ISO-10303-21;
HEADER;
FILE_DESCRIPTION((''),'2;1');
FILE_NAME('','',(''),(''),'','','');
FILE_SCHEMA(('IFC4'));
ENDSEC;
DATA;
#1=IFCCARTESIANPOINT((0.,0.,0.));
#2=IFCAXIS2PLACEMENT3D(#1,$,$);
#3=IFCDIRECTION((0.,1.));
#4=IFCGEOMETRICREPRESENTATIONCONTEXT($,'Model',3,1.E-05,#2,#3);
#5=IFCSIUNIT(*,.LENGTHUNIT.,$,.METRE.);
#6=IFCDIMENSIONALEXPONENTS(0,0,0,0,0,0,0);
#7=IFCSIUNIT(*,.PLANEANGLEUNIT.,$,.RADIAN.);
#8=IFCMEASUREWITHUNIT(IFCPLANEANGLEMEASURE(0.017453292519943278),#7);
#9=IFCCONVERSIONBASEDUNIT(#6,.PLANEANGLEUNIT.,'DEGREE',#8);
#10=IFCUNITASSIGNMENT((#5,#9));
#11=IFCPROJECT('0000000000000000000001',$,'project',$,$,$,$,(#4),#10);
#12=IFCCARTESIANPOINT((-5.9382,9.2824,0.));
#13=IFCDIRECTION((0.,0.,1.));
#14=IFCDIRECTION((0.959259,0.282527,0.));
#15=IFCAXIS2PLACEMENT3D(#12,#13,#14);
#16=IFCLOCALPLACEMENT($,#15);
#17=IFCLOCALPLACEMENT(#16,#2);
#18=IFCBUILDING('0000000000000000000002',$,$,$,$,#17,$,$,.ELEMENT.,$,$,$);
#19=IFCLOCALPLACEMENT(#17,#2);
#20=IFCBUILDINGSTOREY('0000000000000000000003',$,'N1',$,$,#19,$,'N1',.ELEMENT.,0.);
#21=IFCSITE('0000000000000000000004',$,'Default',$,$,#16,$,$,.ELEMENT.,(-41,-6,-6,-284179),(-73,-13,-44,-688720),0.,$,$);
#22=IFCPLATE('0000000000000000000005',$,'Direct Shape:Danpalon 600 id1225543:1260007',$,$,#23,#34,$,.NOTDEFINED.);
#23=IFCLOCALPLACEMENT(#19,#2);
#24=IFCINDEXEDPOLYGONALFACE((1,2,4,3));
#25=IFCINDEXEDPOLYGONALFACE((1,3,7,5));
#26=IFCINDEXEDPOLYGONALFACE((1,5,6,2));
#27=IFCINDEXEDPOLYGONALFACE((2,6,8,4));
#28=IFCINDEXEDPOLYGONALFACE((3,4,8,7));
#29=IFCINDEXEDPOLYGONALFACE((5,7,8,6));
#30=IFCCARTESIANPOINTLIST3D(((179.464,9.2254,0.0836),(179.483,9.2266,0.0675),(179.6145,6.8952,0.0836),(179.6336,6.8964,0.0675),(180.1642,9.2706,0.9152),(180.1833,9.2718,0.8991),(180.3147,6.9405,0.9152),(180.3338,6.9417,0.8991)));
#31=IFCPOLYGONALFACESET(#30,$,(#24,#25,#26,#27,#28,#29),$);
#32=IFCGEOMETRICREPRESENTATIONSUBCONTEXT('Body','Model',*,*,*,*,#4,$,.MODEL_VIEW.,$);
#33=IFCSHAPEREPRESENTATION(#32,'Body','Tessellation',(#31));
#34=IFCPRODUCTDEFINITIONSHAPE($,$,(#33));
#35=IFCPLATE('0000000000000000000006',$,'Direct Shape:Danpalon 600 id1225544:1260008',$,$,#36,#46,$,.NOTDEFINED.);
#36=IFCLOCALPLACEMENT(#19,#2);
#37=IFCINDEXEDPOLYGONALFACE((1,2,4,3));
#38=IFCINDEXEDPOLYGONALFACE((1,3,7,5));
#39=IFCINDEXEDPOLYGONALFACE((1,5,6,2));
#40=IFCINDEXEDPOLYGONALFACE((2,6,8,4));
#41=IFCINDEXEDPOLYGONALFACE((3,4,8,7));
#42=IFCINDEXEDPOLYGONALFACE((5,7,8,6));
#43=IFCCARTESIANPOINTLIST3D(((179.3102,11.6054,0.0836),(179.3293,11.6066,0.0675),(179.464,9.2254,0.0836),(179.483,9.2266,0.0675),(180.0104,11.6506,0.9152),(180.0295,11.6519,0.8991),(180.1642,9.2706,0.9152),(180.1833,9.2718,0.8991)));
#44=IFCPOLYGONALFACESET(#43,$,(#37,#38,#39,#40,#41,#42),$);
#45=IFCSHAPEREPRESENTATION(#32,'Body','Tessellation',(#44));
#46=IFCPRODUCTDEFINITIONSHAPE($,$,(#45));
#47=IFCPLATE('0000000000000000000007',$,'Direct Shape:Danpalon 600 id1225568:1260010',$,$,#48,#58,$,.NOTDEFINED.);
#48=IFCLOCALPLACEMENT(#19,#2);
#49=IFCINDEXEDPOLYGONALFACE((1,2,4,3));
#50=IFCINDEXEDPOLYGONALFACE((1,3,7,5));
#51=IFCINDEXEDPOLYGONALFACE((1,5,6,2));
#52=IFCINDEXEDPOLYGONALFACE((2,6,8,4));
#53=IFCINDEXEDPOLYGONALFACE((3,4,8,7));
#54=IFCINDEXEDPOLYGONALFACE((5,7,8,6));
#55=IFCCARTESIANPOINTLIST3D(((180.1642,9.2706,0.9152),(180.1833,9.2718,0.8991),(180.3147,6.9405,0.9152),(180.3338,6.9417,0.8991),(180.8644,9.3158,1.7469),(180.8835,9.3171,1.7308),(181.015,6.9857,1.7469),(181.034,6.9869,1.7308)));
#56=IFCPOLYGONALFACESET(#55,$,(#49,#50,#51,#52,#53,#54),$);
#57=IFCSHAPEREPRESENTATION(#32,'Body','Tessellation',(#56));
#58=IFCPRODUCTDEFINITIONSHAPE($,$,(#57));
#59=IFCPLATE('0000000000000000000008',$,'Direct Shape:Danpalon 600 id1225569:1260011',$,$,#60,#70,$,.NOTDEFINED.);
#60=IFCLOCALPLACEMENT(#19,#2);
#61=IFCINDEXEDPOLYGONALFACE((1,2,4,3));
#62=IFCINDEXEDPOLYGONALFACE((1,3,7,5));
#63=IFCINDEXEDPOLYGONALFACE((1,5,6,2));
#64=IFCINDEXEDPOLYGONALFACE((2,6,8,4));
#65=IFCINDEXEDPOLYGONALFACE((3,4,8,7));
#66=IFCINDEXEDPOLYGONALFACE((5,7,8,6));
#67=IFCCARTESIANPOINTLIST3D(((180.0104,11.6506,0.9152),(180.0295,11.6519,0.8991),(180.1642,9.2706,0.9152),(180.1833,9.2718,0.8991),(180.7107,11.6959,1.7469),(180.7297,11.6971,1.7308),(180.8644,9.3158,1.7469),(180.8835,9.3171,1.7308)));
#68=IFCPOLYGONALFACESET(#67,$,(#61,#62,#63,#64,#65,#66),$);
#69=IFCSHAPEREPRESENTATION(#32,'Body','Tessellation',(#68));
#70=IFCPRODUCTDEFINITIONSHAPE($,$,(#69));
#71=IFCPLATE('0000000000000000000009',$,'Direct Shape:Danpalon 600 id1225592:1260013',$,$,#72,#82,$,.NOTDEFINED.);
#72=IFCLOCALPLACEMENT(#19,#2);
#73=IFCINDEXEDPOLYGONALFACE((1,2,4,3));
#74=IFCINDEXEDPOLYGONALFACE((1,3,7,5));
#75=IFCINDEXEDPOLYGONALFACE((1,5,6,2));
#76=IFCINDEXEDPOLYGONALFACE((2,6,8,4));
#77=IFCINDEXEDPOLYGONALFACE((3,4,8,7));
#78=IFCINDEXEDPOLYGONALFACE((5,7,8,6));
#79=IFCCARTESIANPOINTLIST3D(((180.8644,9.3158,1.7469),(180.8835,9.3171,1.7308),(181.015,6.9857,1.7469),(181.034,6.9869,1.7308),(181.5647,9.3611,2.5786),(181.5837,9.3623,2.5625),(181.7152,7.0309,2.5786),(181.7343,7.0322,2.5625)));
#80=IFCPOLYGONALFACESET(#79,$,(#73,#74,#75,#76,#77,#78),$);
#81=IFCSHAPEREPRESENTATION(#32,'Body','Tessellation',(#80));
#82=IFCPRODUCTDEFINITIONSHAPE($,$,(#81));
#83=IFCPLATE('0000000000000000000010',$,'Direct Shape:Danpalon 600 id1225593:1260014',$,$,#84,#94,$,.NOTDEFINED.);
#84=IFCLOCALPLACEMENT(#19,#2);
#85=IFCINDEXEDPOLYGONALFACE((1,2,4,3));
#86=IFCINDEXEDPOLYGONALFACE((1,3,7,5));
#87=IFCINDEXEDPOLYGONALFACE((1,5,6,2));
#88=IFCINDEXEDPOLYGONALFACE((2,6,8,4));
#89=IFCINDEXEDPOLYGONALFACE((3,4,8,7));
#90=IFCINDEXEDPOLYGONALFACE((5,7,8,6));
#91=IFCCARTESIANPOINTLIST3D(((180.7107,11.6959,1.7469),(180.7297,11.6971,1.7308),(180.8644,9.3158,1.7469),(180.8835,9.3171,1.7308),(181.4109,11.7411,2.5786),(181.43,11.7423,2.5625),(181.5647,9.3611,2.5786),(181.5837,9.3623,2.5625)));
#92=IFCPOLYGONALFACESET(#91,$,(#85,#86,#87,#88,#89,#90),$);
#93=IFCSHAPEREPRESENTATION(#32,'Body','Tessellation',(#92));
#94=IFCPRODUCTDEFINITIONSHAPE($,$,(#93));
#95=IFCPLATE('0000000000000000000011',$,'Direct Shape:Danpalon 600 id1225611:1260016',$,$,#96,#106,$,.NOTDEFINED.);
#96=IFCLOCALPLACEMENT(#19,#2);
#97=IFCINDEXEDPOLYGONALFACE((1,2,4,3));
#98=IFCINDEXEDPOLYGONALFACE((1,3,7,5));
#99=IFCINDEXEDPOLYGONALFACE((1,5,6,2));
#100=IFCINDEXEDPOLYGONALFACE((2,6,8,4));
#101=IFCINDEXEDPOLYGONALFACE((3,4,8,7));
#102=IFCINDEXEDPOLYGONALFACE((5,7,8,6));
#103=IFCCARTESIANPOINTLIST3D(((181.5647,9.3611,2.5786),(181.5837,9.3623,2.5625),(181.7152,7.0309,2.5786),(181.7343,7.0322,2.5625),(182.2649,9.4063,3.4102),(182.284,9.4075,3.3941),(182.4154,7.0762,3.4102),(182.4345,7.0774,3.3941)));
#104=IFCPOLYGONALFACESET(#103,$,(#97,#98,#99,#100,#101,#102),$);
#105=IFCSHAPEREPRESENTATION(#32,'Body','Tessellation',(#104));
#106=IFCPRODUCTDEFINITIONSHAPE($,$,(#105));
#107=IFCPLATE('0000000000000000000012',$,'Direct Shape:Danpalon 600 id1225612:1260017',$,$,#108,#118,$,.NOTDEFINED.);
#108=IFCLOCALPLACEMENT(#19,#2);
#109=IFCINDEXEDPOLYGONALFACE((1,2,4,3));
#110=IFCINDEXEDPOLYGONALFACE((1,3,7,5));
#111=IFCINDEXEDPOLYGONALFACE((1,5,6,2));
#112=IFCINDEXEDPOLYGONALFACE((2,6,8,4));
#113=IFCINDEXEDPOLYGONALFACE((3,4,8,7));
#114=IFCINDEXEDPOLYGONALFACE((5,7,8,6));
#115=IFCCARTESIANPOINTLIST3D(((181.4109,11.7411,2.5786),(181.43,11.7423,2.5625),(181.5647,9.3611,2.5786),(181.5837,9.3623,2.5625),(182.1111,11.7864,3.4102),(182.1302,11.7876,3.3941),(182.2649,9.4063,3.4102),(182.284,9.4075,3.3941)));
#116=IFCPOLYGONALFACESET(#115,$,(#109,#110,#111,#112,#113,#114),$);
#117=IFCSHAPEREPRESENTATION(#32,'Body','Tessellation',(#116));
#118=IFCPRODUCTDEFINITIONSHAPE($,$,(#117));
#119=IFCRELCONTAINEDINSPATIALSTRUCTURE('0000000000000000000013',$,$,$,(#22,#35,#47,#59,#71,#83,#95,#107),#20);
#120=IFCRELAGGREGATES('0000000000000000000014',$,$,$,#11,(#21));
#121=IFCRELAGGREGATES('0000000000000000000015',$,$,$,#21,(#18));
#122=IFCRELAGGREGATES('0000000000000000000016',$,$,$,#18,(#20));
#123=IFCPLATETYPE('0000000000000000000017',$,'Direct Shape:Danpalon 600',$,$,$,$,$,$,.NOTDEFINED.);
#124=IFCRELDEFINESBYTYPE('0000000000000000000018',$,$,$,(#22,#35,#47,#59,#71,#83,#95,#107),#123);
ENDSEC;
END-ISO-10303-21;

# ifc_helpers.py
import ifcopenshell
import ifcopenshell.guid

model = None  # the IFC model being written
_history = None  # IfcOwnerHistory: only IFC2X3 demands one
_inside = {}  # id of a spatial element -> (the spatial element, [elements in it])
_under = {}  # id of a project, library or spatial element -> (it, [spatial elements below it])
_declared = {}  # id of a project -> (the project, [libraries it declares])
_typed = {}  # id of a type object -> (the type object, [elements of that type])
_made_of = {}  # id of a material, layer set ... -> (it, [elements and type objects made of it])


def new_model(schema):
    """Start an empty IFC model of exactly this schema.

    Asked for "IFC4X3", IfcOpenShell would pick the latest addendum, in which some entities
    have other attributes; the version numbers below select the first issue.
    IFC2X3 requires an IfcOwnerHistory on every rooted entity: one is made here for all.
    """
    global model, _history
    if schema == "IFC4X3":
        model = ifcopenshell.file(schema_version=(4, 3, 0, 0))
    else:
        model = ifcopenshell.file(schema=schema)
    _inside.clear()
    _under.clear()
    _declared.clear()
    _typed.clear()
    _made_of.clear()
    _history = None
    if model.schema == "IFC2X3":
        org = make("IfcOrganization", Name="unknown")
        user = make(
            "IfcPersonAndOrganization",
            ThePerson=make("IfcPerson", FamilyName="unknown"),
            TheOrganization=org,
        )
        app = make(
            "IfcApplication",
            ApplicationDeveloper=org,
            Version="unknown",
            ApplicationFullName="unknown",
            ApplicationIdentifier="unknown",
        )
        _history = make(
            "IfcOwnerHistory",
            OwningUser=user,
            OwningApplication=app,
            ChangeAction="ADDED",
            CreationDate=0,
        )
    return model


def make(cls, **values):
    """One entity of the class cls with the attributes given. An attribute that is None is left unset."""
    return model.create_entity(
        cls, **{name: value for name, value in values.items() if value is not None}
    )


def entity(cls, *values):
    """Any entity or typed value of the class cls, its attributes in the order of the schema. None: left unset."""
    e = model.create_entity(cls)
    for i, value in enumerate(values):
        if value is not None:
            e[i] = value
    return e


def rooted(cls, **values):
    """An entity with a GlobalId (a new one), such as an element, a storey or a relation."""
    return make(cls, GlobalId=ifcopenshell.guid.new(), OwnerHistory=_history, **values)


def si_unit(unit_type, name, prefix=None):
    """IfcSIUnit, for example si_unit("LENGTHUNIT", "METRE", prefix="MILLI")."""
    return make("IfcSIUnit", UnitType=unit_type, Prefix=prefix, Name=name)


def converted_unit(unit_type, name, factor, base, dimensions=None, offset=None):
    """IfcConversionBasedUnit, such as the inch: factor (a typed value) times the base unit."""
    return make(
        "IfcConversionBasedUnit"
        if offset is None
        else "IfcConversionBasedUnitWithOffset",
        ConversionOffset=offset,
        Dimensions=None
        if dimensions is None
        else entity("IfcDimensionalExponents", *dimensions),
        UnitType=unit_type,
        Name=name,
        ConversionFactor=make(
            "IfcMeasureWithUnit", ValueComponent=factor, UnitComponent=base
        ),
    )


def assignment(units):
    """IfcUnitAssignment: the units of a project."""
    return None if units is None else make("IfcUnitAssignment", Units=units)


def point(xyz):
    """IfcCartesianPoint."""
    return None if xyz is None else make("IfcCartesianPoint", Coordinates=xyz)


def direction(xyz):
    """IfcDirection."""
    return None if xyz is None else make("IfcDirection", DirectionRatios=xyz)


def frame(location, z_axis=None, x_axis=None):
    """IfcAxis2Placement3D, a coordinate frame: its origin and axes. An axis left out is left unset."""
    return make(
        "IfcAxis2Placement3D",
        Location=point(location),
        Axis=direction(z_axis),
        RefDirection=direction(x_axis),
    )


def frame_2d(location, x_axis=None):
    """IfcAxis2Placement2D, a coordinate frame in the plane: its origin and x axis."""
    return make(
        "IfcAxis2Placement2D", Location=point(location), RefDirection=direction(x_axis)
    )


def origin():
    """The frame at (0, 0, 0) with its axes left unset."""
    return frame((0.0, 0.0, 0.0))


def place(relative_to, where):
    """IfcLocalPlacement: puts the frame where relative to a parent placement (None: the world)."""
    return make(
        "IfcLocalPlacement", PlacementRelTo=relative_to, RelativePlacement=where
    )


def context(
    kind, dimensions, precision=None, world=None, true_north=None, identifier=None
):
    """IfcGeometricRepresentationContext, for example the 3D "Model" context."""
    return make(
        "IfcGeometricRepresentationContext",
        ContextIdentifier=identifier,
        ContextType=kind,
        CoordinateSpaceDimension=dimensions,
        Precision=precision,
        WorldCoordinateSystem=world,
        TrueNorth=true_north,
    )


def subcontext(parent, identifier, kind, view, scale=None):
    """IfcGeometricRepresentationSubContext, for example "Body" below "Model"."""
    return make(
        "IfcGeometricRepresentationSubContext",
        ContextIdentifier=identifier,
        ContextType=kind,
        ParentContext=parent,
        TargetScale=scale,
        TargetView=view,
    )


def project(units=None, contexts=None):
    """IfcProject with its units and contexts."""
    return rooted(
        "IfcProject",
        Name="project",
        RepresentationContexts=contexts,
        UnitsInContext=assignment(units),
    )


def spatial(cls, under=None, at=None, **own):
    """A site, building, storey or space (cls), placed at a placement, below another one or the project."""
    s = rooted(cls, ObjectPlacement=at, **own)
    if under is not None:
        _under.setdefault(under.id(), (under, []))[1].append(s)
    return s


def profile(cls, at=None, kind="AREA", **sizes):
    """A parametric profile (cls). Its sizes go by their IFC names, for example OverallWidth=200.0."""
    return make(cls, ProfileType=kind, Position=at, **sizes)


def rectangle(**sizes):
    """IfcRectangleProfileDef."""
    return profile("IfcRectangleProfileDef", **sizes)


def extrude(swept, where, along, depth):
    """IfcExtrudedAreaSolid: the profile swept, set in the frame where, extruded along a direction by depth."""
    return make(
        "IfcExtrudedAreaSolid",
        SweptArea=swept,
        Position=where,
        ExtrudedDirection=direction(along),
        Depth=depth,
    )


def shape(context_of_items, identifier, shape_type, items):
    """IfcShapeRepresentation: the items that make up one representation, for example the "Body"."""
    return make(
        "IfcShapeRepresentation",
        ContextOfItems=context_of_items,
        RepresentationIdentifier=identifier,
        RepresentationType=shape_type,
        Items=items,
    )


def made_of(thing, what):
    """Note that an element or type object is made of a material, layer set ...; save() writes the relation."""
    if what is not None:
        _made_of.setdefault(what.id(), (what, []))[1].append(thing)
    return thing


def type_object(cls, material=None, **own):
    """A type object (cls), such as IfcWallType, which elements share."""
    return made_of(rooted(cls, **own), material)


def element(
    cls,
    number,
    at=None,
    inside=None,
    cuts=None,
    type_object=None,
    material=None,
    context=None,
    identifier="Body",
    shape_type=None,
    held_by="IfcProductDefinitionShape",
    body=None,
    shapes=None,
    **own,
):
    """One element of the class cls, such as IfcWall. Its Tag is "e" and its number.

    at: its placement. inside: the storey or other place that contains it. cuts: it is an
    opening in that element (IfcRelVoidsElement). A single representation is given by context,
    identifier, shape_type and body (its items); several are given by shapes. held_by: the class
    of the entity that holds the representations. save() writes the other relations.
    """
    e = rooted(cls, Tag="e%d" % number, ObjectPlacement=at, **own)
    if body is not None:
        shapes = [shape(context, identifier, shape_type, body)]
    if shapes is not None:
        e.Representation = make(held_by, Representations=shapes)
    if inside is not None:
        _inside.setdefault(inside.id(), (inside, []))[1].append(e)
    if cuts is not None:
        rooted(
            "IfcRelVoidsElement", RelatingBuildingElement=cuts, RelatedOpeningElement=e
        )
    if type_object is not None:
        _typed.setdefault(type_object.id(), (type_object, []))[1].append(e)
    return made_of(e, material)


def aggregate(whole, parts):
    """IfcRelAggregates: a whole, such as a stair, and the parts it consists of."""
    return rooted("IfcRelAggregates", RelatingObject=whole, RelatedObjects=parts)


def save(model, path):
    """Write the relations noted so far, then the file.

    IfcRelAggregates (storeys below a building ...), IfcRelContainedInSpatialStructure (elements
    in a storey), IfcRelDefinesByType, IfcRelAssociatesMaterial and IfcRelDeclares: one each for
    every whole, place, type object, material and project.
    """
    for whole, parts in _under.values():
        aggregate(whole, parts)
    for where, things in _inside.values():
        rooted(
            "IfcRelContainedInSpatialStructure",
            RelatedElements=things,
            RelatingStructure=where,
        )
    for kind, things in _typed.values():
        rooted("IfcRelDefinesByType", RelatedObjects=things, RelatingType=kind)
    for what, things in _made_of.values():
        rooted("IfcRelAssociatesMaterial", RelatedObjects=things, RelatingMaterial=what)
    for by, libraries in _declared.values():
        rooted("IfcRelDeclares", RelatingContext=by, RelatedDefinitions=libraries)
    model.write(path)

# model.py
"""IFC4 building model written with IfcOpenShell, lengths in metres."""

from ifc_helpers import new_model, entity, si_unit, converted_unit, direction, frame, frame_2d, origin, place, context, subcontext, project, spatial, rectangle, extrude, type_object, element, save


model = new_model("IFC4")

# Units and contexts
model_context = context("Model", 3, precision=1e-05, world=origin(), true_north=direction((0.0, 1.0)))
body_context = subcontext(model_context, "Body", "Model", "MODEL_VIEW")
ifc_project = project(units=[si_unit("LENGTHUNIT", "METRE"), converted_unit("PLANEANGLEUNIT", "DEGREE", entity("IfcPlaneAngleMeasure", 0.017453292519943278), si_unit("PLANEANGLEUNIT", "RADIAN"), dimensions=[0, 0, 0, 0, 0, 0, 0])], contexts=[model_context])

# Site, building, storey
site_placement = place(None, frame((-5.9382, 9.2824, 0.0), z_axis=(0.0, 0.0, 1.0), x_axis=(0.959259, 0.282527, 0.0)))
site = spatial("IfcSite", under=ifc_project, at=site_placement, Name="Default", CompositionType="ELEMENT", RefLatitude=(-41, -6, -6, -284179), RefLongitude=(-73, -13, -44, -688720), RefElevation=0.0)
building_placement = place(site_placement, origin())
building = spatial("IfcBuilding", under=site, at=building_placement, CompositionType="ELEMENT")
storey_placement = place(building_placement, origin())
storey = spatial("IfcBuildingStorey", under=building, at=storey_placement, Name="N1", LongName="N1", CompositionType="ELEMENT", Elevation=0.0)

# Plates
plate_type = type_object("IfcPlateType", Name="Direct Shape:Danpalon 600", PredefinedType="NOTDEFINED")
plate_1_placement = place(storey_placement, origin())
element("IfcPlate", 1, at=plate_1_placement, inside=storey, type_object=plate_type, Name="Direct Shape:Danpalon 600 id1225543:1260007", PredefinedType="NOTDEFINED", context=body_context, shape_type="SweptSolid", body=[
    extrude(rectangle(XDim=1.0881, YDim=0.025, at=frame_2d((0.0, 0.0), x_axis=(0.0, 1.0))), frame((179.9742, 6.9185, 0.4914), z_axis=(-0.064471, 0.99792, 0.0), x_axis=(-0.762714, -0.049276, 0.644857)), (0.0, 0.0, 1.0), 2.335),
])
plate_2_placement = place(storey_placement, origin())
element("IfcPlate", 2, at=plate_2_placement, inside=storey, type_object=plate_type, Name="Direct Shape:Danpalon 600 id1225544:1260008", PredefinedType="NOTDEFINED", context=body_context, shape_type="SweptSolid", body=[
    extrude(rectangle(XDim=1.0881, YDim=0.025, at=frame_2d((0.0, 0.0), x_axis=(0.0, 1.0))), frame((179.8236, 9.2486, 0.4914), z_axis=(-0.064471, 0.99792, 0.0), x_axis=(-0.762714, -0.049276, 0.644857)), (0.0, 0.0, 1.0), 2.385),
])
plate_3_placement = place(storey_placement, origin())
element("IfcPlate", 3, at=plate_3_placement, inside=storey, type_object=plate_type, Name="Direct Shape:Danpalon 600 id1225568:1260010", PredefinedType="NOTDEFINED", context=body_context, shape_type="SweptSolid", body=[
    extrude(rectangle(XDim=1.0881, YDim=0.025, at=frame_2d((0.0, 0.0), x_axis=(0.0, 1.0))), frame((180.6744, 6.9637, 1.323), z_axis=(-0.064471, 0.99792, 0.0), x_axis=(-0.762714, -0.049276, 0.644857)), (0.0, 0.0, 1.0), 2.335),
])
plate_4_placement = place(storey_placement, origin())
element("IfcPlate", 4, at=plate_4_placement, inside=storey, type_object=plate_type, Name="Direct Shape:Danpalon 600 id1225569:1260011", PredefinedType="NOTDEFINED", context=body_context, shape_type="SweptSolid", body=[
    extrude(rectangle(XDim=1.0881, YDim=0.025, at=frame_2d((0.0, 0.0), x_axis=(0.0, 1.0))), frame((180.5238, 9.2938, 1.323), z_axis=(-0.064471, 0.99792, 0.0), x_axis=(-0.762714, -0.049276, 0.644857)), (0.0, 0.0, 1.0), 2.385),
])
plate_5_placement = place(storey_placement, origin())
element("IfcPlate", 5, at=plate_5_placement, inside=storey, type_object=plate_type, Name="Direct Shape:Danpalon 600 id1225592:1260013", PredefinedType="NOTDEFINED", context=body_context, shape_type="SweptSolid", body=[
    extrude(rectangle(XDim=1.0881, YDim=0.025, at=frame_2d((0.0, 0.0), x_axis=(0.0, 1.0))), frame((181.3746, 7.0089, 2.1547), z_axis=(-0.064471, 0.99792, 0.0), x_axis=(-0.762714, -0.049276, 0.644857)), (0.0, 0.0, 1.0), 2.335),
])
plate_6_placement = place(storey_placement, origin())
element("IfcPlate", 6, at=plate_6_placement, inside=storey, type_object=plate_type, Name="Direct Shape:Danpalon 600 id1225593:1260014", PredefinedType="NOTDEFINED", context=body_context, shape_type="SweptSolid", body=[
    extrude(rectangle(XDim=1.0881, YDim=0.025, at=frame_2d((0.0, 0.0), x_axis=(0.0, 1.0))), frame((181.2241, 9.3391, 2.1547), z_axis=(-0.064471, 0.99792, 0.0), x_axis=(-0.762714, -0.049276, 0.644857)), (0.0, 0.0, 1.0), 2.385),
])
plate_7_placement = place(storey_placement, origin())
element("IfcPlate", 7, at=plate_7_placement, inside=storey, type_object=plate_type, Name="Direct Shape:Danpalon 600 id1225611:1260016", PredefinedType="NOTDEFINED", context=body_context, shape_type="SweptSolid", body=[
    extrude(rectangle(XDim=1.0881, YDim=0.025, at=frame_2d((0.0, 0.0), x_axis=(0.0, 1.0))), frame((182.0748, 7.0542, 2.9864), z_axis=(-0.064471, 0.99792, 0.0), x_axis=(-0.762714, -0.049276, 0.644857)), (0.0, 0.0, 1.0), 2.335),
])
plate_8_placement = place(storey_placement, origin())
element("IfcPlate", 8, at=plate_8_placement, inside=storey, type_object=plate_type, Name="Direct Shape:Danpalon 600 id1225612:1260017", PredefinedType="NOTDEFINED", context=body_context, shape_type="SweptSolid", body=[
    extrude(rectangle(XDim=1.0881, YDim=0.025, at=frame_2d((0.0, 0.0), x_axis=(0.0, 1.0))), frame((181.9243, 9.3843, 2.9864), z_axis=(-0.064471, 0.99792, 0.0), x_axis=(-0.762714, -0.049276, 0.644857)), (0.0, 0.0, 1.0), 2.385),
])

save(model, "model.ifc")
